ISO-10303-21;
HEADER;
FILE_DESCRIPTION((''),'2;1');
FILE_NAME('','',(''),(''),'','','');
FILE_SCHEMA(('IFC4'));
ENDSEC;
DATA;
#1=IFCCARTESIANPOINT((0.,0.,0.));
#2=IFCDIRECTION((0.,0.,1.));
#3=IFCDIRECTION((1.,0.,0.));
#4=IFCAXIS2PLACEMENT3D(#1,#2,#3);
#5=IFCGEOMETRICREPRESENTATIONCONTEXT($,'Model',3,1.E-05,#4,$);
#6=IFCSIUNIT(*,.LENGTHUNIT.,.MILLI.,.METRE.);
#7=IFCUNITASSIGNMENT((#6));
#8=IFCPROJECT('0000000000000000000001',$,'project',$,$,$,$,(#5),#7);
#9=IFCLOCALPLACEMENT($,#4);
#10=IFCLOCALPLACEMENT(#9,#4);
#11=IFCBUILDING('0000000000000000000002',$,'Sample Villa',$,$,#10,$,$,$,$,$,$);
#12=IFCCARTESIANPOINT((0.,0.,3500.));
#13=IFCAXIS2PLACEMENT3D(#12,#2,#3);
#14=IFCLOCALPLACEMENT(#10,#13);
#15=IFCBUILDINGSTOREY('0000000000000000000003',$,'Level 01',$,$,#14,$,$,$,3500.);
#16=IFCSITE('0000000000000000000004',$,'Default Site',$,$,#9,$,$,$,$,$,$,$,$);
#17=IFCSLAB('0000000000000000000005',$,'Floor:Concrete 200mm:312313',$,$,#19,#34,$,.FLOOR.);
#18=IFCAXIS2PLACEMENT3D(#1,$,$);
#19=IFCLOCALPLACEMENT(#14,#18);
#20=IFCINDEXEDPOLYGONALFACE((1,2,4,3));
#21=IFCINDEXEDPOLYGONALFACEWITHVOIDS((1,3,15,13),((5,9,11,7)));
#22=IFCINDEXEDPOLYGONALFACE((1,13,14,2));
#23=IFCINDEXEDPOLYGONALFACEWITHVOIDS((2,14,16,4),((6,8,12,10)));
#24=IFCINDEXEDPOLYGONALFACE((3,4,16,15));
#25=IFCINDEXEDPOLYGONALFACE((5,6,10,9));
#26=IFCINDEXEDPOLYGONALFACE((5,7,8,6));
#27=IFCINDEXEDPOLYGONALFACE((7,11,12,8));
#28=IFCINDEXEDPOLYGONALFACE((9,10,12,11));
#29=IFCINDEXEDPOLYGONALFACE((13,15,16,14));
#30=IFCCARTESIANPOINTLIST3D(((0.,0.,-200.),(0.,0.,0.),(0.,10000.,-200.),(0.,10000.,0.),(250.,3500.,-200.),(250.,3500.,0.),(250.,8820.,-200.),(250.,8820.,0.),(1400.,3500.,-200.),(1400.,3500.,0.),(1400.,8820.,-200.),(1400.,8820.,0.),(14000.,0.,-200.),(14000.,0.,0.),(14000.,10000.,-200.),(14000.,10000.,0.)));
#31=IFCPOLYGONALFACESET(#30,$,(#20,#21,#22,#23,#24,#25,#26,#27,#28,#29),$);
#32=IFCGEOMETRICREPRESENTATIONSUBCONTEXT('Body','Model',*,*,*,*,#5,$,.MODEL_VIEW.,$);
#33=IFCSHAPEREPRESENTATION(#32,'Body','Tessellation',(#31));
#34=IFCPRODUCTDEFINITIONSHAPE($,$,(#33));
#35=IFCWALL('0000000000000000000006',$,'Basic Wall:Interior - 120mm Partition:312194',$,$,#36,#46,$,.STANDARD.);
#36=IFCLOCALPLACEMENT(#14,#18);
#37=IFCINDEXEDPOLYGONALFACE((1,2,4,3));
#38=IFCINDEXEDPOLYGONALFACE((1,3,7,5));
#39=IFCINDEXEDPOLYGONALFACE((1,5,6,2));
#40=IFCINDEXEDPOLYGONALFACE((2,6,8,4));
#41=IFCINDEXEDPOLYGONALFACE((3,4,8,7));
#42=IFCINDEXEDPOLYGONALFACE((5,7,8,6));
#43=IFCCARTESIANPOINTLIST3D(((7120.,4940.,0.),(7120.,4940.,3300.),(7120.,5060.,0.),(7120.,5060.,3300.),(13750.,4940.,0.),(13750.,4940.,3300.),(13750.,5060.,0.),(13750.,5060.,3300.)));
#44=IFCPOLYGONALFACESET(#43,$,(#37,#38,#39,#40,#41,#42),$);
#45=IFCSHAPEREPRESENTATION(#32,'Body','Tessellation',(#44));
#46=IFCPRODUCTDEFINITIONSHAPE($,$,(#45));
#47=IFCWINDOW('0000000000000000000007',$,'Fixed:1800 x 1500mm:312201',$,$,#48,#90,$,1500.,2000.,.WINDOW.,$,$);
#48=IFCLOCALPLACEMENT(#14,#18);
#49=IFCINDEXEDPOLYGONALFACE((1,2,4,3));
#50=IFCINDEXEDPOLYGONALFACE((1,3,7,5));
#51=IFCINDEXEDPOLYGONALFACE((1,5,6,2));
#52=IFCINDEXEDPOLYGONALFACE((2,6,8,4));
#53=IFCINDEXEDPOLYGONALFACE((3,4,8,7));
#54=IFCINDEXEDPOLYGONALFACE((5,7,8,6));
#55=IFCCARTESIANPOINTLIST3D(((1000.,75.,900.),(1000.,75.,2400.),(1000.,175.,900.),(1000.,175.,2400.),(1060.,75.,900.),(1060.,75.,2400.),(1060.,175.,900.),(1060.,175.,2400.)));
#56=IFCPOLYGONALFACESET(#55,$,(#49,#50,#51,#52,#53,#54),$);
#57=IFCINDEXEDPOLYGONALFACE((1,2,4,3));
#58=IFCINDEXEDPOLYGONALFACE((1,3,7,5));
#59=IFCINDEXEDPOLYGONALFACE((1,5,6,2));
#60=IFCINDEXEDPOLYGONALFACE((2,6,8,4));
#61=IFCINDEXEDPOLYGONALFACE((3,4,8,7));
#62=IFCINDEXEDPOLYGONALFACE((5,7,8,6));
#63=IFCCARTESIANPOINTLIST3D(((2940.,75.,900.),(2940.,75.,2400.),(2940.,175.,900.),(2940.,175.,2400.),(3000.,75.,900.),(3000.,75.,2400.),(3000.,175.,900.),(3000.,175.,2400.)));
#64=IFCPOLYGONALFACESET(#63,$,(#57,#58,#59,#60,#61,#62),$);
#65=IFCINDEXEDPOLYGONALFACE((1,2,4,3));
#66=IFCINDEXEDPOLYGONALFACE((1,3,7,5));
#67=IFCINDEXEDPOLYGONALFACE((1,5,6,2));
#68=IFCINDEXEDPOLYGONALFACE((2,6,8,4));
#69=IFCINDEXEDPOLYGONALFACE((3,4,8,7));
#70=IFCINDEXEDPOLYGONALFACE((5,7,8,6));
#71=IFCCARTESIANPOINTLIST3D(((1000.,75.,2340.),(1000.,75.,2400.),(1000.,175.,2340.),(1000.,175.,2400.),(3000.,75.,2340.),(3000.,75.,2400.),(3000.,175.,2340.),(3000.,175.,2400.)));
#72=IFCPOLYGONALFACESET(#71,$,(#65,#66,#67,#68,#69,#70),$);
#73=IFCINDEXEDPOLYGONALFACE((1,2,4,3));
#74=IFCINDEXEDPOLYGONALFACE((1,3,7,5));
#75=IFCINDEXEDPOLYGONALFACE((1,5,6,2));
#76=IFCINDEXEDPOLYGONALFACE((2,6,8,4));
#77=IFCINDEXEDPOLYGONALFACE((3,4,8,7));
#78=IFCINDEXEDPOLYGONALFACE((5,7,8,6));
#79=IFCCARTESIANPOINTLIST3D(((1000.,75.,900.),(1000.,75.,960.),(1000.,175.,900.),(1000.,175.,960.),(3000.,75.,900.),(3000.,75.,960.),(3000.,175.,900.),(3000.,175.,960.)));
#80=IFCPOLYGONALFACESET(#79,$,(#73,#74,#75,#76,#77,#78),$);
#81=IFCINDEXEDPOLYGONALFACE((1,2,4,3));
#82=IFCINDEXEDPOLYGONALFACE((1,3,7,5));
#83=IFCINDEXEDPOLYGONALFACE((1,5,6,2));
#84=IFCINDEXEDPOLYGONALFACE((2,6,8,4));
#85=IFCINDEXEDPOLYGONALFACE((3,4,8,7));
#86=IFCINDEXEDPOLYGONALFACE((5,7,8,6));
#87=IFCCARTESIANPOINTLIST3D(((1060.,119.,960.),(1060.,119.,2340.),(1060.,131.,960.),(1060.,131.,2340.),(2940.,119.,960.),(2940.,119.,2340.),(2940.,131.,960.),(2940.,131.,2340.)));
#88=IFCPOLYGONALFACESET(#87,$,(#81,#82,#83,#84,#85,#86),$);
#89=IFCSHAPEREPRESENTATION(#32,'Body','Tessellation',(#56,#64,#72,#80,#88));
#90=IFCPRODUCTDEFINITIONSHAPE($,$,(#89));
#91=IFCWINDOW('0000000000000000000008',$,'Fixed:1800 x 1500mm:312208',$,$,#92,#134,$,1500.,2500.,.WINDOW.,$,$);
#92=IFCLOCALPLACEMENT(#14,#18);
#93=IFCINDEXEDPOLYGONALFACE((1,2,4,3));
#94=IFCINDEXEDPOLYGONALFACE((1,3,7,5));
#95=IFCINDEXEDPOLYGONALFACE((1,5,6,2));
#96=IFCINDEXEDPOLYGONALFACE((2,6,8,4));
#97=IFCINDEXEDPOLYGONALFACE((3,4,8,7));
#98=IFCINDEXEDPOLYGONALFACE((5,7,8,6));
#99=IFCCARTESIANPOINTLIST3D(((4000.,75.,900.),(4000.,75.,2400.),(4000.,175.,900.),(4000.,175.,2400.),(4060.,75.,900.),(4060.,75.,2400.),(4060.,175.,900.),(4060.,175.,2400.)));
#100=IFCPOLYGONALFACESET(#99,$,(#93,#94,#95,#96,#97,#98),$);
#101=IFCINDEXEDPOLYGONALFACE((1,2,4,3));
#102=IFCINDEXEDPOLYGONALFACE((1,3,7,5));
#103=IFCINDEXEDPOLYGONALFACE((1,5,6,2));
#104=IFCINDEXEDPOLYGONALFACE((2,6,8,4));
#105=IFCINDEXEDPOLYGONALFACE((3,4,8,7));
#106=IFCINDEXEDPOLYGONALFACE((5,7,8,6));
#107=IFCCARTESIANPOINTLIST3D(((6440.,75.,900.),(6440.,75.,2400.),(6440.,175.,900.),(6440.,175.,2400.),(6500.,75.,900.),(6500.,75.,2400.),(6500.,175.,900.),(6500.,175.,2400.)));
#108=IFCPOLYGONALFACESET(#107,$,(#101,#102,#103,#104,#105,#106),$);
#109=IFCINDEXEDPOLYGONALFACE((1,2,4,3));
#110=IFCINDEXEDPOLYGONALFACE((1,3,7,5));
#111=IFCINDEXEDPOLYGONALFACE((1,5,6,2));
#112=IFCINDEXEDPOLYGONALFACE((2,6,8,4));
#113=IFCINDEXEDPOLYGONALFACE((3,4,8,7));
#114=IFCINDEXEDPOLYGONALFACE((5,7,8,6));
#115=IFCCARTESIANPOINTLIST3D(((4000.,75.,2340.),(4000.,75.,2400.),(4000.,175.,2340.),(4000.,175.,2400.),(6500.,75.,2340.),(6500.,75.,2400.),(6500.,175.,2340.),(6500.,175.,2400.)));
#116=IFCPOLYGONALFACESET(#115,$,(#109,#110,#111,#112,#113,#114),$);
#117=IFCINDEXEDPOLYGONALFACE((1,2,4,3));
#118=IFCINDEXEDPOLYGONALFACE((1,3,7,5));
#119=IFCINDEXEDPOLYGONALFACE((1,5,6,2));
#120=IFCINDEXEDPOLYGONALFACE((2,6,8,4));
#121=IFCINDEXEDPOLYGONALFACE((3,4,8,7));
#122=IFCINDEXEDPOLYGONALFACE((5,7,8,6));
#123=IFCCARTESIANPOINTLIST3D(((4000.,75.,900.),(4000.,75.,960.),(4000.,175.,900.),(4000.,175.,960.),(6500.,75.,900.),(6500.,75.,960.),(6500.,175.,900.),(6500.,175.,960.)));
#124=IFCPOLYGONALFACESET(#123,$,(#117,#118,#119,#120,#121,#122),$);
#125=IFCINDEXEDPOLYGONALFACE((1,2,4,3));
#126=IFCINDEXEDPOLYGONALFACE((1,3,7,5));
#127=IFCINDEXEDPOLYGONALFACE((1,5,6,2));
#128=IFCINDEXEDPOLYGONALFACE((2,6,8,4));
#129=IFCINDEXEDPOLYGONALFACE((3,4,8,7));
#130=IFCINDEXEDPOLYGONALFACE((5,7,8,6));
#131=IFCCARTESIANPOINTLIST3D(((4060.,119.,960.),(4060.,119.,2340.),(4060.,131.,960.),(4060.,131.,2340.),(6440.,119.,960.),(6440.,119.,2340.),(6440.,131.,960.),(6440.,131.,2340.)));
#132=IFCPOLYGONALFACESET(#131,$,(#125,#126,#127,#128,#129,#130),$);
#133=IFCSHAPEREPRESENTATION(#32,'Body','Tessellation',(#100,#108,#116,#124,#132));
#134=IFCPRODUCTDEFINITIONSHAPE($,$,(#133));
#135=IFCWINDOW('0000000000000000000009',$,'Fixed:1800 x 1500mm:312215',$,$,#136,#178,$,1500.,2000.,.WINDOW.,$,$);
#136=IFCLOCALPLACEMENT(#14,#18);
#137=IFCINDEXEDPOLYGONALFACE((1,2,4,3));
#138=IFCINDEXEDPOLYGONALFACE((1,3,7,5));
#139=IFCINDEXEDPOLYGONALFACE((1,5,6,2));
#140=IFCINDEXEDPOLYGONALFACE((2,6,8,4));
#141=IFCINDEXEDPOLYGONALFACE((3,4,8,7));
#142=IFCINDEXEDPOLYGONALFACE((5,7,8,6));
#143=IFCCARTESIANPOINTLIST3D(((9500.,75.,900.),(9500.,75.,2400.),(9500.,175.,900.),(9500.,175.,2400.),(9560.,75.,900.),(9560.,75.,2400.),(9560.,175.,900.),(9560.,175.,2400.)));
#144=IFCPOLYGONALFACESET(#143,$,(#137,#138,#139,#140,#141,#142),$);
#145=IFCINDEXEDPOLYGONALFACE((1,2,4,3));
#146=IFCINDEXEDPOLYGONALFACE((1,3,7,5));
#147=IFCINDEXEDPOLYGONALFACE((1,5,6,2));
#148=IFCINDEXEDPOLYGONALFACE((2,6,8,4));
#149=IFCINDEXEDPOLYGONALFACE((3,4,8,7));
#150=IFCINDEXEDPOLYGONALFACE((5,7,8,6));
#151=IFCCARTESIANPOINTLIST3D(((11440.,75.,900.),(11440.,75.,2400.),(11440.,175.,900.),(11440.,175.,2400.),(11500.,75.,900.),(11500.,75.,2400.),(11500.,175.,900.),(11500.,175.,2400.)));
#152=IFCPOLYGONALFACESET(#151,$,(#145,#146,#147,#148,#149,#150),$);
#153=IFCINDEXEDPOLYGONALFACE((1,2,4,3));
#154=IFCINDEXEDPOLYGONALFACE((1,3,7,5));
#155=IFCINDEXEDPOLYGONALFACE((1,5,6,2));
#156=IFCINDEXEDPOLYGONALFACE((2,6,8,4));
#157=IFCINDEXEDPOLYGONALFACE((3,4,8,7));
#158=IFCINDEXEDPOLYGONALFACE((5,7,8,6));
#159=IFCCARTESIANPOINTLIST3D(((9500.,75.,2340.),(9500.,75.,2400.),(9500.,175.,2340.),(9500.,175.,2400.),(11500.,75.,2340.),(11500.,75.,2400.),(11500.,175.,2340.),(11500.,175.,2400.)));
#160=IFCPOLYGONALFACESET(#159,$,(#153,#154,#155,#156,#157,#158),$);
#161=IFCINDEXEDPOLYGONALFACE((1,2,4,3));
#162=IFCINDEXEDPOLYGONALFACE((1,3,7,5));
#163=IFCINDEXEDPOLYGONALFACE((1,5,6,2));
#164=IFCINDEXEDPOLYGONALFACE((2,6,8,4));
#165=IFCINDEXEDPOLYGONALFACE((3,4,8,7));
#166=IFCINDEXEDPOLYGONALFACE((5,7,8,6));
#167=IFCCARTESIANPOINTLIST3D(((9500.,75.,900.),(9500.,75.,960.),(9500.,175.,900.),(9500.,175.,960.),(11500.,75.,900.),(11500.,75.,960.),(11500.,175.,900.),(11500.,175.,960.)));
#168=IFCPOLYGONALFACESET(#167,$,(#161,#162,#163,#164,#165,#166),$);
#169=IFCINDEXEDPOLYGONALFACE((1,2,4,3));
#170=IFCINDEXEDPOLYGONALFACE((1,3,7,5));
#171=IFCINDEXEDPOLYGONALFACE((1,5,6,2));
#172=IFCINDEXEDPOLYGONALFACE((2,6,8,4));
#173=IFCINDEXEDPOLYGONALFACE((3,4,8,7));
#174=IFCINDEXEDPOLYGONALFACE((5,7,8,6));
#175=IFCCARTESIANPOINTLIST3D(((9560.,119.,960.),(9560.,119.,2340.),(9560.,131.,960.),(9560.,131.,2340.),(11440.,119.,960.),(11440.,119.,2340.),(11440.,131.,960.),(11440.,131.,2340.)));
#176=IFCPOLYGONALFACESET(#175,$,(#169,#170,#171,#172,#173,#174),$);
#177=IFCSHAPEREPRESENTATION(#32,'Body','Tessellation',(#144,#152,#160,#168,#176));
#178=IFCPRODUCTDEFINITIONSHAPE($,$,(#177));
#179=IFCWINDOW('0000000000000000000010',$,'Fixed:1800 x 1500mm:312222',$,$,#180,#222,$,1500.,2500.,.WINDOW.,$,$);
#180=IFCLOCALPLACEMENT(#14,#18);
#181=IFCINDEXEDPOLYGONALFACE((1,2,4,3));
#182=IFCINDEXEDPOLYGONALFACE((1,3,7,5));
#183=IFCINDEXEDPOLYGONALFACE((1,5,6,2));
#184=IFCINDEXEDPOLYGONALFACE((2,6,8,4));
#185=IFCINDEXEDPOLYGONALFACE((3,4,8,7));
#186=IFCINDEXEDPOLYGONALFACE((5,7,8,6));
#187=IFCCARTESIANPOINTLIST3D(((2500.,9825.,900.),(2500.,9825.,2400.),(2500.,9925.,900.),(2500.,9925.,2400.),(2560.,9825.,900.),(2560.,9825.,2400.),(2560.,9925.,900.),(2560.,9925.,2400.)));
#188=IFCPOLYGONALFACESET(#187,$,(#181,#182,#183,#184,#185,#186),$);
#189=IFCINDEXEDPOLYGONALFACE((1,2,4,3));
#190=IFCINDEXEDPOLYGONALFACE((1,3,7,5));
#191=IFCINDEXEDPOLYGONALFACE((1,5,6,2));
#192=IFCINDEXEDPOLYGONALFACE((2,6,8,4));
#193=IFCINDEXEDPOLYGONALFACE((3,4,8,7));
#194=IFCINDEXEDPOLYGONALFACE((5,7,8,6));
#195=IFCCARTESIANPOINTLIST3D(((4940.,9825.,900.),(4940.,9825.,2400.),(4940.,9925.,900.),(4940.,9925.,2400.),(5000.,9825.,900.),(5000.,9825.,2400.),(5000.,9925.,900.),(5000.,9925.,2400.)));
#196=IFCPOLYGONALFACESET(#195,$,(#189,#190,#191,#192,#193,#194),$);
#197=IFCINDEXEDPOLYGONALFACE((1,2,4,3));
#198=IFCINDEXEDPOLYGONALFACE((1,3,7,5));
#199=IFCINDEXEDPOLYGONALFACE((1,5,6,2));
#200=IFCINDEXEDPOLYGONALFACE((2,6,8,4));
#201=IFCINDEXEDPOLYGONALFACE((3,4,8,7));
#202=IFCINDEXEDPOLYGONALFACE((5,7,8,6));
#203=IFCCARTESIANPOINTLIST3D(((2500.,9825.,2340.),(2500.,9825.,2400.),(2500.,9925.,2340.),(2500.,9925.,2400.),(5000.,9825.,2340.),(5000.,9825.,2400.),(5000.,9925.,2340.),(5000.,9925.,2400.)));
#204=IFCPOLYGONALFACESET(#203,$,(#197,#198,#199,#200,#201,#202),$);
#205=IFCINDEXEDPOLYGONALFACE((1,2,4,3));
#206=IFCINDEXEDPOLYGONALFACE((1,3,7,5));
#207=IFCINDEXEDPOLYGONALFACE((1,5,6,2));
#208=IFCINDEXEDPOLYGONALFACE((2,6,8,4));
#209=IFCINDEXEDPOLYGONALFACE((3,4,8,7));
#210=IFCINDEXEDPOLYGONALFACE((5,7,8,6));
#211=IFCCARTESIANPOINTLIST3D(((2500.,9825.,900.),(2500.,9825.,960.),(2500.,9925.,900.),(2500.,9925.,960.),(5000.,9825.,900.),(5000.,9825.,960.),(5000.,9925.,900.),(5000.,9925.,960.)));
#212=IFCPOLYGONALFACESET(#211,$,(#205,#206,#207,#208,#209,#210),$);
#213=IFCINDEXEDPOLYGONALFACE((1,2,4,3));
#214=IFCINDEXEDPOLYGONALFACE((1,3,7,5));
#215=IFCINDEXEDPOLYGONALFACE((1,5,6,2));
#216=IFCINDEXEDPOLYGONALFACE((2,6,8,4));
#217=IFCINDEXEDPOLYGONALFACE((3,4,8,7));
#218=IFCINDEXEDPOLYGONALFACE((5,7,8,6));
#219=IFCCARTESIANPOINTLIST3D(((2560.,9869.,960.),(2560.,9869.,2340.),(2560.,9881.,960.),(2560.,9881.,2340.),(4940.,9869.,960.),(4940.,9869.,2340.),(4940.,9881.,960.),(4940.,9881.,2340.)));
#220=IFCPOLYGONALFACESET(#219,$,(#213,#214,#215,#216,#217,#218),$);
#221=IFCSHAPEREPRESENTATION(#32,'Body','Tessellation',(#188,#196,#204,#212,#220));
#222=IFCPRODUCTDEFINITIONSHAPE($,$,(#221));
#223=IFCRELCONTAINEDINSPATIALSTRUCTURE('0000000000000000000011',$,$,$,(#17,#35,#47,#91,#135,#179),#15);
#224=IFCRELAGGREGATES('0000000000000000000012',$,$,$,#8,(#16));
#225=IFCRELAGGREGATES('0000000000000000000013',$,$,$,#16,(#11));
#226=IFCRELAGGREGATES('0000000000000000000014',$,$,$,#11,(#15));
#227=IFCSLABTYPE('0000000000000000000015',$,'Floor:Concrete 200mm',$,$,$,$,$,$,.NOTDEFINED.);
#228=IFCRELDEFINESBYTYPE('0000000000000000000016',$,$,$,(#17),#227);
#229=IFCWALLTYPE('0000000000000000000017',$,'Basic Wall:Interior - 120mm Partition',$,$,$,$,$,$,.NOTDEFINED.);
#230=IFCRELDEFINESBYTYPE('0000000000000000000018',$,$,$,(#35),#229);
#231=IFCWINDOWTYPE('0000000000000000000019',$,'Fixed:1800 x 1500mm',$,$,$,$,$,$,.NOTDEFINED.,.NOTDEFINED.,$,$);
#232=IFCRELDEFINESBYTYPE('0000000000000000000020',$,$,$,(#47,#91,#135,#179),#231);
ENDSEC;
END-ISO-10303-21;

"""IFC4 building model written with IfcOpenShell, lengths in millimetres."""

from ifc_helpers import new_model, si_unit, frame, frame_2d, origin_with_axes, place, context, subcontext, project, spatial, rectangle, extrude, type_object, element, save


model = new_model("IFC4")

# Units and contexts
model_context = context("Model", 3, precision=1e-05, world=origin_with_axes())
body_context = subcontext(model_context, "Body", "Model", "MODEL_VIEW")
ifc_project = project(units=[si_unit("LENGTHUNIT", "METRE", prefix="MILLI")], contexts=[model_context])

# Site, building, storey
site_placement = place(None, origin_with_axes())
site = spatial("IfcSite", under=ifc_project, at=site_placement, Name="Default Site")
building_placement = place(site_placement, origin_with_axes())
building = spatial("IfcBuilding", under=site, at=building_placement, Name="Sample Villa")
storey_placement = place(building_placement, frame((0.0, 0.0, 3500.0), z_axis=(0.0, 0.0, 1.0), x_axis=(1.0, 0.0, 0.0)))
storey = spatial("IfcBuildingStorey", under=building, at=storey_placement, Name="Level 01", Elevation=3500.0)

# Slab, opening
slab_type = type_object("IfcSlabType", Name="Floor:Concrete 200mm", PredefinedType="NOTDEFINED")
slab_placement = place(storey_placement, frame((0.0, 0.0, -3500.0), z_axis=(0.0, 0.0, 1.0), x_axis=(1.0, 0.0, 0.0)))
slab = element("IfcSlab", 1, at=slab_placement, inside=storey, type_object=slab_type, Name="Floor:Concrete 200mm:312313", PredefinedType="FLOOR", context=body_context, shape_type="SweptSolid", body=[
    extrude(rectangle(XDim=14000.0, YDim=10000.0, at=frame_2d((7000.0, 5000.0))), frame((0.0, 0.0, 3300.0)), (0.0, 0.0, 1.0), 200.0),
])
opening_1_placement = place(slab_placement, origin_with_axes())
element("IfcOpeningElement", 2, at=opening_1_placement, cuts=slab, context=body_context, shape_type="SweptSolid", body=[
    extrude(rectangle(XDim=1150.0, YDim=5320.0, at=frame_2d((575.0, 2660.0))), frame((250.0, 3500.0, 3200.0)), (0.0, 0.0, 1.0), 400.0),
])

# Shared definitions
wall_type_1 = type_object("IfcWallType", Name="Basic Wall:Interior - 120mm Partition", PredefinedType="NOTDEFINED")

# Wall
wall_1_placement = place(storey_placement, frame((0.0, 0.0, -3500.0), z_axis=(0.0, 0.0, 1.0), x_axis=(1.0, 0.0, 0.0)))
element("IfcWall", 3, at=wall_1_placement, inside=storey, type_object=wall_type_1, Name="Basic Wall:Interior - 120mm Partition:312194", PredefinedType="STANDARD", context=body_context, shape_type="SweptSolid", body=[
    extrude(rectangle(XDim=6630.0, YDim=120.0, at=frame_2d((3315.0, 60.0))), frame((7120.0, 4940.0, 3500.0)), (0.0, 0.0, 1.0), 3300.0),
])

# Windows
window_type = type_object("IfcWindowType", Name="Fixed:1800 x 1500mm", PartitioningType="NOTDEFINED", PredefinedType="NOTDEFINED")
window_1_placement = place(storey_placement, frame((0.0, 0.0, -3500.0), z_axis=(0.0, 0.0, 1.0), x_axis=(1.0, 0.0, 0.0)))
element("IfcWindow", 4, at=window_1_placement, inside=storey, type_object=window_type, Name="Fixed:1800 x 1500mm:312201", OverallHeight=1500.0, OverallWidth=2000.0, PredefinedType="WINDOW", context=body_context, shape_type="SweptSolid", body=[
    extrude(rectangle(XDim=60.0, YDim=100.0, at=frame_2d((30.0, 50.0))), frame((1000.0, 75.0, 4400.0)), (0.0, 0.0, 1.0), 1500.0),
    extrude(rectangle(XDim=60.0, YDim=100.0, at=frame_2d((30.0, 50.0))), frame((2940.0, 75.0, 4400.0)), (0.0, 0.0, 1.0), 1500.0),
    extrude(rectangle(XDim=2000.0, YDim=100.0, at=frame_2d((1000.0, 50.0))), frame((1000.0, 75.0, 5840.0)), (0.0, 0.0, 1.0), 60.0),
    extrude(rectangle(XDim=2000.0, YDim=100.0, at=frame_2d((1000.0, 50.0))), frame((1000.0, 75.0, 4400.0)), (0.0, 0.0, 1.0), 60.0),
    extrude(rectangle(XDim=1880.0, YDim=12.0, at=frame_2d((940.0, 6.0))), frame((1060.0, 119.0, 4460.0)), (0.0, 0.0, 1.0), 1380.0),
])
window_2_placement = place(storey_placement, frame((0.0, 0.0, -3500.0), z_axis=(0.0, 0.0, 1.0), x_axis=(1.0, 0.0, 0.0)))
element("IfcWindow", 5, at=window_2_placement, inside=storey, type_object=window_type, Name="Fixed:1800 x 1500mm:312208", OverallHeight=1500.0, OverallWidth=2500.0, PredefinedType="WINDOW", context=body_context, shape_type="SweptSolid", body=[
    extrude(rectangle(XDim=60.0, YDim=100.0, at=frame_2d((30.0, 50.0))), frame((4000.0, 75.0, 4400.0)), (0.0, 0.0, 1.0), 1500.0),
    extrude(rectangle(XDim=60.0, YDim=100.0, at=frame_2d((30.0, 50.0))), frame((6440.0, 75.0, 4400.0)), (0.0, 0.0, 1.0), 1500.0),
    extrude(rectangle(XDim=2500.0, YDim=100.0, at=frame_2d((1250.0, 50.0))), frame((4000.0, 75.0, 5840.0)), (0.0, 0.0, 1.0), 60.0),
    extrude(rectangle(XDim=2500.0, YDim=100.0, at=frame_2d((1250.0, 50.0))), frame((4000.0, 75.0, 4400.0)), (0.0, 0.0, 1.0), 60.0),
    extrude(rectangle(XDim=2380.0, YDim=12.0, at=frame_2d((1190.0, 6.0))), frame((4060.0, 119.0, 4460.0)), (0.0, 0.0, 1.0), 1380.0),
])
window_3_placement = place(storey_placement, frame((0.0, 0.0, -3500.0), z_axis=(0.0, 0.0, 1.0), x_axis=(1.0, 0.0, 0.0)))
element("IfcWindow", 6, at=window_3_placement, inside=storey, type_object=window_type, Name="Fixed:1800 x 1500mm:312215", OverallHeight=1500.0, OverallWidth=2000.0, PredefinedType="WINDOW", context=body_context, shape_type="SweptSolid", body=[
    extrude(rectangle(XDim=60.0, YDim=100.0, at=frame_2d((30.0, 50.0))), frame((9500.0, 75.0, 4400.0)), (0.0, 0.0, 1.0), 1500.0),
    extrude(rectangle(XDim=60.0, YDim=100.0, at=frame_2d((30.0, 50.0))), frame((11440.0, 75.0, 4400.0)), (0.0, 0.0, 1.0), 1500.0),
    extrude(rectangle(XDim=2000.0, YDim=100.0, at=frame_2d((1000.0, 50.0))), frame((9500.0, 75.0, 5840.0)), (0.0, 0.0, 1.0), 60.0),
    extrude(rectangle(XDim=2000.0, YDim=100.0, at=frame_2d((1000.0, 50.0))), frame((9500.0, 75.0, 4400.0)), (0.0, 0.0, 1.0), 60.0),
    extrude(rectangle(XDim=1880.0, YDim=12.0, at=frame_2d((940.0, 6.0))), frame((9560.0, 119.0, 4460.0)), (0.0, 0.0, 1.0), 1380.0),
])
window_4_placement = place(storey_placement, frame((0.0, 0.0, -3500.0), z_axis=(0.0, 0.0, 1.0), x_axis=(1.0, 0.0, 0.0)))
element("IfcWindow", 7, at=window_4_placement, inside=storey, type_object=window_type, Name="Fixed:1800 x 1500mm:312222", OverallHeight=1500.0, OverallWidth=2500.0, PredefinedType="WINDOW", context=body_context, shape_type="SweptSolid", body=[
    extrude(rectangle(XDim=60.0, YDim=100.0, at=frame_2d((30.0, 50.0))), frame((2500.0, 9825.0, 4400.0)), (0.0, 0.0, 1.0), 1500.0),
    extrude(rectangle(XDim=60.0, YDim=100.0, at=frame_2d((30.0, 50.0))), frame((4940.0, 9825.0, 4400.0)), (0.0, 0.0, 1.0), 1500.0),
    extrude(rectangle(XDim=2500.0, YDim=100.0, at=frame_2d((1250.0, 50.0))), frame((2500.0, 9825.0, 5840.0)), (0.0, 0.0, 1.0), 60.0),
    extrude(rectangle(XDim=2500.0, YDim=100.0, at=frame_2d((1250.0, 50.0))), frame((2500.0, 9825.0, 4400.0)), (0.0, 0.0, 1.0), 60.0),
    extrude(rectangle(XDim=2380.0, YDim=12.0, at=frame_2d((1190.0, 6.0))), frame((2560.0, 9869.0, 4460.0)), (0.0, 0.0, 1.0), 1380.0),
])

save(model, "model.ifc")
